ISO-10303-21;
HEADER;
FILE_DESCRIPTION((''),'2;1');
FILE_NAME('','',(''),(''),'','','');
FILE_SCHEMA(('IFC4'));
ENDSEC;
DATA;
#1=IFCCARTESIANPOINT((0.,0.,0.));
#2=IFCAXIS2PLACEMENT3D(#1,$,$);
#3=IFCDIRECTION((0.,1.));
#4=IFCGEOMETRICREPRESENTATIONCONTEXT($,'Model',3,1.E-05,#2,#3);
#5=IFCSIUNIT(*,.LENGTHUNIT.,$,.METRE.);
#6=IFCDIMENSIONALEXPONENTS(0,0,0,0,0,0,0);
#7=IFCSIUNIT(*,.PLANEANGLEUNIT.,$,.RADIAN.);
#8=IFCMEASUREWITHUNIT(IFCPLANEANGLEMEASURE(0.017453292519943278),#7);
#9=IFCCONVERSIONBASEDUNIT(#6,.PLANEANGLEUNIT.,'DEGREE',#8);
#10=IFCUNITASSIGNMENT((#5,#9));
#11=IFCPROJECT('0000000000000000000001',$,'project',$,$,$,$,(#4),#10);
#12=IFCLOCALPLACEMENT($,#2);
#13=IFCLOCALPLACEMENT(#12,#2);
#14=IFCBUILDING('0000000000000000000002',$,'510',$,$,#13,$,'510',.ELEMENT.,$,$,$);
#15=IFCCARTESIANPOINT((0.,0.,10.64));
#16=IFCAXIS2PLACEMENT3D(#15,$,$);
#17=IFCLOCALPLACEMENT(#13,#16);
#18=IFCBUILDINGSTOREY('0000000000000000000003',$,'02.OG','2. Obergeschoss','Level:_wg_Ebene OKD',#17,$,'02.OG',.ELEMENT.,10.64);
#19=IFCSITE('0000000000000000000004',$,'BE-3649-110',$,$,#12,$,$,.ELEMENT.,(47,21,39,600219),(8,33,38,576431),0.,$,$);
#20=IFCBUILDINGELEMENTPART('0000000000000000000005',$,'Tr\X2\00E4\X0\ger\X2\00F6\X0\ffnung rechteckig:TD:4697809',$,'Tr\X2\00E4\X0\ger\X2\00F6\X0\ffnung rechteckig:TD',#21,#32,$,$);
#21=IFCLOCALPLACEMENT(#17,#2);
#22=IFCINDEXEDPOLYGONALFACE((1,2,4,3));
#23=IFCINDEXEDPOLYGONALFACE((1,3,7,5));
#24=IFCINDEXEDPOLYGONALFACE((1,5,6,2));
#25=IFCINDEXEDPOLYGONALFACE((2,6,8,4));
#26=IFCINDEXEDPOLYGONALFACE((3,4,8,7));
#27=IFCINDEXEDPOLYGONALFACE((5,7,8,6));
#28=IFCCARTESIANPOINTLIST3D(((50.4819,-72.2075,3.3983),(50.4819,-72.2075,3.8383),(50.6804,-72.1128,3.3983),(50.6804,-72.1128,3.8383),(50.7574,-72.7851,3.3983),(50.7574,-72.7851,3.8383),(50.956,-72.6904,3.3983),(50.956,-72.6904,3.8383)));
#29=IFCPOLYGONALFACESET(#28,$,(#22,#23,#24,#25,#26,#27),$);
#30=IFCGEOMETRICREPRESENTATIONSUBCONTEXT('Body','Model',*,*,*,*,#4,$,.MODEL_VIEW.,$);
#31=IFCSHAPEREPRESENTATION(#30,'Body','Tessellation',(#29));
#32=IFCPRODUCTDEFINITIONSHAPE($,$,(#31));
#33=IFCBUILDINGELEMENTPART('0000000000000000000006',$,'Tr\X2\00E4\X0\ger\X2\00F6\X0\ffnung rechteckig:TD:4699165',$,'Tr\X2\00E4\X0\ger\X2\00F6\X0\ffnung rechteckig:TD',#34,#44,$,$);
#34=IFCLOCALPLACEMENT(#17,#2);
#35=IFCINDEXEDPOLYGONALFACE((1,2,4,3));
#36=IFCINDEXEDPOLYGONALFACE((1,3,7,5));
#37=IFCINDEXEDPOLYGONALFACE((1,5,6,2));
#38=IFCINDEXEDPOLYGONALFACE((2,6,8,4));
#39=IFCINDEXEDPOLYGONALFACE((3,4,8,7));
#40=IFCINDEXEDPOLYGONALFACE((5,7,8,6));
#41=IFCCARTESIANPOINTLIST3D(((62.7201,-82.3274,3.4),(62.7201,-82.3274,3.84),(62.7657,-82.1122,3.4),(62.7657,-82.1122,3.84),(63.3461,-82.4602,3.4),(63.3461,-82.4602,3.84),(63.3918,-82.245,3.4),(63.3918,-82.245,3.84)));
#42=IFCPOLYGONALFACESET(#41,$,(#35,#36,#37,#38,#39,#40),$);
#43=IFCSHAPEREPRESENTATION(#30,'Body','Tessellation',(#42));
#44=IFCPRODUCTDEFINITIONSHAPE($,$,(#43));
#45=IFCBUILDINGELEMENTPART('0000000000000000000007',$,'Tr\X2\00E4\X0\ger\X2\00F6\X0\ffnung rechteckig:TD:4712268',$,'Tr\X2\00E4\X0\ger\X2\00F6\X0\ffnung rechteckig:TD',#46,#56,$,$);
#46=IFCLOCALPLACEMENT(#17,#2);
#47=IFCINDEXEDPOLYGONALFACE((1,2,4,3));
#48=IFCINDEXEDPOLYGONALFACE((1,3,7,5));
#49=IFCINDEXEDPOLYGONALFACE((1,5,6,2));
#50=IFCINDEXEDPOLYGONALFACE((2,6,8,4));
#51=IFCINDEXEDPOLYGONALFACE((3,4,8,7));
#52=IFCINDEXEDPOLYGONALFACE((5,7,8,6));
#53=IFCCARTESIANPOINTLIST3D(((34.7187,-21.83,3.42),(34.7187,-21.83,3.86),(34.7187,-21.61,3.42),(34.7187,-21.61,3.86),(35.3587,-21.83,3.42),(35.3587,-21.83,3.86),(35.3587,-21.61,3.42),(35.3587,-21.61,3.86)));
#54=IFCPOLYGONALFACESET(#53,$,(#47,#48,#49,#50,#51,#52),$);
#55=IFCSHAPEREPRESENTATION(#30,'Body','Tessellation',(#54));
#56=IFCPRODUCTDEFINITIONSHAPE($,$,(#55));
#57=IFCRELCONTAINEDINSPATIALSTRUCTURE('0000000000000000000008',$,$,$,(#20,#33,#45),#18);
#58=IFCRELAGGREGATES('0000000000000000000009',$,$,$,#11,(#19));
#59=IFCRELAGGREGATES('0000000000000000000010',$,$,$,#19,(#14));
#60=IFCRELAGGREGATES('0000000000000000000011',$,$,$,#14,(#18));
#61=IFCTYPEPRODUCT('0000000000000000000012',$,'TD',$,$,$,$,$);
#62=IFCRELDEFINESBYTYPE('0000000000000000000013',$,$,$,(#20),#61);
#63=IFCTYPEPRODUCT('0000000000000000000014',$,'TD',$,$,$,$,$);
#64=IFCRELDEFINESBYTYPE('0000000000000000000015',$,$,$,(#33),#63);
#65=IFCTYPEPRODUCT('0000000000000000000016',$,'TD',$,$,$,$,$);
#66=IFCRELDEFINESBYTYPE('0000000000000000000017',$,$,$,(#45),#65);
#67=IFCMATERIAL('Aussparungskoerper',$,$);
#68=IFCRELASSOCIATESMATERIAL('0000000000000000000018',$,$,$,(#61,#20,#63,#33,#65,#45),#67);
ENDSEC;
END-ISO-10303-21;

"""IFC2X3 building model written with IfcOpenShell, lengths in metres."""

from ifc_helpers import new_model, entity, si_unit, converted_unit, direction, frame, frame_2d, origin, origin_2d_with_axis, place, context, subcontext, project, spatial, rectangle, extrude, source, transform, mapped, material, type_object, type_shapes, element, save


model = new_model("IFC2X3")

# Units and contexts
model_context = context("Model", 3, precision=1e-05, world=origin(), true_north=direction((0.0, 1.0)))
body_context = subcontext(model_context, "Body", "Model", "MODEL_VIEW")
ifc_project = project(units=[si_unit("LENGTHUNIT", "METRE"), converted_unit("PLANEANGLEUNIT", "DEGREE", entity("IfcPlaneAngleMeasure", 0.017453292519943278), si_unit("PLANEANGLEUNIT", "RADIAN"), dimensions=[0, 0, 0, 0, 0, 0, 0])], contexts=[model_context])

# Site, building, storey
site_placement = place(None, origin())
site = spatial("IfcSite", under=ifc_project, at=site_placement, Name="BE-3649-110", CompositionType="ELEMENT", RefLatitude=(47, 21, 39, 600219), RefLongitude=(8, 33, 38, 576431), RefElevation=0.0)
building_placement = place(site_placement, origin())
building = spatial("IfcBuilding", under=site, at=building_placement, Name="510", LongName="510", CompositionType="ELEMENT")
storey_placement = place(building_placement, frame((0.0, 0.0, 10.64)))
storey = spatial("IfcBuildingStorey", under=building, at=storey_placement, Name="02.OG", Description="2. Obergeschoss", ObjectType="Level:_wg_Ebene OKD", LongName="02.OG", CompositionType="ELEMENT", Elevation=10.64)

# Building element parts
ifc_material_1 = material(Name="Aussparungskoerper")
type_product_1 = type_object("IfcTypeProduct", Name="TD", material=ifc_material_1)
shared_shape_1 = source(origin(), body_context, "Body", "SweptSolid", [
    extrude(rectangle(XDim=0.22, YDim=0.64, at=frame_2d((0.0, 0.0), x_axis=(1.0, 0.0))), frame((50.7189, -72.449, -0.44), z_axis=(0.0, 0.0, 1.0), x_axis=(0.902586, 0.43051, 0.0)), (0.0, 0.0, 1.0), 0.44),
])
type_shapes(type_product_1, [shared_shape_1])
building_element_part_1_placement = place(storey_placement, frame((0.0, 0.0, 3.8383)))
element("IfcBuildingElementPart", 1, at=building_element_part_1_placement, inside=storey, type_object=type_product_1, material=ifc_material_1, Name="Trägeröffnung rechteckig:TD:4697809", ObjectType="Trägeröffnung rechteckig:TD", context=body_context, shape_type="MappedRepresentation", body=[
    mapped(shared_shape_1, transform((0.0, 0.0, 0.0), scale=1.0)),
])
type_product_2 = type_object("IfcTypeProduct", Name="TD", material=ifc_material_1)
shared_shape_2 = source(origin(), body_context, "Body", "SweptSolid", [
    extrude(rectangle(XDim=0.44, YDim=0.64, at=origin_2d_with_axis()), frame((0.0, 0.0, -0.22), z_axis=(0.0, 0.0, 1.0), x_axis=(0.0, 1.0, 0.0)), (0.0, 0.0, 1.0), 0.22),
])
type_shapes(type_product_2, [shared_shape_2])
building_element_part_2_placement = place(storey_placement, frame((63.0331, -82.3938, 3.62), z_axis=(-0.207566, -0.978221, 0.0), x_axis=(0.978221, -0.207566, 0.0)))
element("IfcBuildingElementPart", 2, at=building_element_part_2_placement, inside=storey, type_object=type_product_2, material=ifc_material_1, Name="Trägeröffnung rechteckig:TD:4699165", ObjectType="Trägeröffnung rechteckig:TD", context=body_context, shape_type="MappedRepresentation", body=[
    mapped(shared_shape_2, transform((0.0, 0.0, 0.0), scale=1.0)),
])
type_product_3 = type_object("IfcTypeProduct", Name="TD", material=ifc_material_1)
shared_shape_3 = source(origin(), body_context, "Body", "SweptSolid", [
    extrude(rectangle(XDim=0.22, YDim=0.64, at=frame_2d((0.0, 0.0), x_axis=(1.0, 0.0))), frame((35.0387, -21.72, -0.44), z_axis=(0.0, 0.0, 1.0), x_axis=(0.0, 1.0, 0.0)), (0.0, 0.0, 1.0), 0.44),
])
type_shapes(type_product_3, [shared_shape_3])
building_element_part_3_placement = place(storey_placement, frame((0.0, 0.0, 3.86)))
element("IfcBuildingElementPart", 3, at=building_element_part_3_placement, inside=storey, type_object=type_product_3, material=ifc_material_1, Name="Trägeröffnung rechteckig:TD:4712268", ObjectType="Trägeröffnung rechteckig:TD", context=body_context, shape_type="MappedRepresentation", body=[
    mapped(shared_shape_3, transform((0.0, 0.0, 0.0), scale=1.0)),
])

save(model, "model.ifc")
